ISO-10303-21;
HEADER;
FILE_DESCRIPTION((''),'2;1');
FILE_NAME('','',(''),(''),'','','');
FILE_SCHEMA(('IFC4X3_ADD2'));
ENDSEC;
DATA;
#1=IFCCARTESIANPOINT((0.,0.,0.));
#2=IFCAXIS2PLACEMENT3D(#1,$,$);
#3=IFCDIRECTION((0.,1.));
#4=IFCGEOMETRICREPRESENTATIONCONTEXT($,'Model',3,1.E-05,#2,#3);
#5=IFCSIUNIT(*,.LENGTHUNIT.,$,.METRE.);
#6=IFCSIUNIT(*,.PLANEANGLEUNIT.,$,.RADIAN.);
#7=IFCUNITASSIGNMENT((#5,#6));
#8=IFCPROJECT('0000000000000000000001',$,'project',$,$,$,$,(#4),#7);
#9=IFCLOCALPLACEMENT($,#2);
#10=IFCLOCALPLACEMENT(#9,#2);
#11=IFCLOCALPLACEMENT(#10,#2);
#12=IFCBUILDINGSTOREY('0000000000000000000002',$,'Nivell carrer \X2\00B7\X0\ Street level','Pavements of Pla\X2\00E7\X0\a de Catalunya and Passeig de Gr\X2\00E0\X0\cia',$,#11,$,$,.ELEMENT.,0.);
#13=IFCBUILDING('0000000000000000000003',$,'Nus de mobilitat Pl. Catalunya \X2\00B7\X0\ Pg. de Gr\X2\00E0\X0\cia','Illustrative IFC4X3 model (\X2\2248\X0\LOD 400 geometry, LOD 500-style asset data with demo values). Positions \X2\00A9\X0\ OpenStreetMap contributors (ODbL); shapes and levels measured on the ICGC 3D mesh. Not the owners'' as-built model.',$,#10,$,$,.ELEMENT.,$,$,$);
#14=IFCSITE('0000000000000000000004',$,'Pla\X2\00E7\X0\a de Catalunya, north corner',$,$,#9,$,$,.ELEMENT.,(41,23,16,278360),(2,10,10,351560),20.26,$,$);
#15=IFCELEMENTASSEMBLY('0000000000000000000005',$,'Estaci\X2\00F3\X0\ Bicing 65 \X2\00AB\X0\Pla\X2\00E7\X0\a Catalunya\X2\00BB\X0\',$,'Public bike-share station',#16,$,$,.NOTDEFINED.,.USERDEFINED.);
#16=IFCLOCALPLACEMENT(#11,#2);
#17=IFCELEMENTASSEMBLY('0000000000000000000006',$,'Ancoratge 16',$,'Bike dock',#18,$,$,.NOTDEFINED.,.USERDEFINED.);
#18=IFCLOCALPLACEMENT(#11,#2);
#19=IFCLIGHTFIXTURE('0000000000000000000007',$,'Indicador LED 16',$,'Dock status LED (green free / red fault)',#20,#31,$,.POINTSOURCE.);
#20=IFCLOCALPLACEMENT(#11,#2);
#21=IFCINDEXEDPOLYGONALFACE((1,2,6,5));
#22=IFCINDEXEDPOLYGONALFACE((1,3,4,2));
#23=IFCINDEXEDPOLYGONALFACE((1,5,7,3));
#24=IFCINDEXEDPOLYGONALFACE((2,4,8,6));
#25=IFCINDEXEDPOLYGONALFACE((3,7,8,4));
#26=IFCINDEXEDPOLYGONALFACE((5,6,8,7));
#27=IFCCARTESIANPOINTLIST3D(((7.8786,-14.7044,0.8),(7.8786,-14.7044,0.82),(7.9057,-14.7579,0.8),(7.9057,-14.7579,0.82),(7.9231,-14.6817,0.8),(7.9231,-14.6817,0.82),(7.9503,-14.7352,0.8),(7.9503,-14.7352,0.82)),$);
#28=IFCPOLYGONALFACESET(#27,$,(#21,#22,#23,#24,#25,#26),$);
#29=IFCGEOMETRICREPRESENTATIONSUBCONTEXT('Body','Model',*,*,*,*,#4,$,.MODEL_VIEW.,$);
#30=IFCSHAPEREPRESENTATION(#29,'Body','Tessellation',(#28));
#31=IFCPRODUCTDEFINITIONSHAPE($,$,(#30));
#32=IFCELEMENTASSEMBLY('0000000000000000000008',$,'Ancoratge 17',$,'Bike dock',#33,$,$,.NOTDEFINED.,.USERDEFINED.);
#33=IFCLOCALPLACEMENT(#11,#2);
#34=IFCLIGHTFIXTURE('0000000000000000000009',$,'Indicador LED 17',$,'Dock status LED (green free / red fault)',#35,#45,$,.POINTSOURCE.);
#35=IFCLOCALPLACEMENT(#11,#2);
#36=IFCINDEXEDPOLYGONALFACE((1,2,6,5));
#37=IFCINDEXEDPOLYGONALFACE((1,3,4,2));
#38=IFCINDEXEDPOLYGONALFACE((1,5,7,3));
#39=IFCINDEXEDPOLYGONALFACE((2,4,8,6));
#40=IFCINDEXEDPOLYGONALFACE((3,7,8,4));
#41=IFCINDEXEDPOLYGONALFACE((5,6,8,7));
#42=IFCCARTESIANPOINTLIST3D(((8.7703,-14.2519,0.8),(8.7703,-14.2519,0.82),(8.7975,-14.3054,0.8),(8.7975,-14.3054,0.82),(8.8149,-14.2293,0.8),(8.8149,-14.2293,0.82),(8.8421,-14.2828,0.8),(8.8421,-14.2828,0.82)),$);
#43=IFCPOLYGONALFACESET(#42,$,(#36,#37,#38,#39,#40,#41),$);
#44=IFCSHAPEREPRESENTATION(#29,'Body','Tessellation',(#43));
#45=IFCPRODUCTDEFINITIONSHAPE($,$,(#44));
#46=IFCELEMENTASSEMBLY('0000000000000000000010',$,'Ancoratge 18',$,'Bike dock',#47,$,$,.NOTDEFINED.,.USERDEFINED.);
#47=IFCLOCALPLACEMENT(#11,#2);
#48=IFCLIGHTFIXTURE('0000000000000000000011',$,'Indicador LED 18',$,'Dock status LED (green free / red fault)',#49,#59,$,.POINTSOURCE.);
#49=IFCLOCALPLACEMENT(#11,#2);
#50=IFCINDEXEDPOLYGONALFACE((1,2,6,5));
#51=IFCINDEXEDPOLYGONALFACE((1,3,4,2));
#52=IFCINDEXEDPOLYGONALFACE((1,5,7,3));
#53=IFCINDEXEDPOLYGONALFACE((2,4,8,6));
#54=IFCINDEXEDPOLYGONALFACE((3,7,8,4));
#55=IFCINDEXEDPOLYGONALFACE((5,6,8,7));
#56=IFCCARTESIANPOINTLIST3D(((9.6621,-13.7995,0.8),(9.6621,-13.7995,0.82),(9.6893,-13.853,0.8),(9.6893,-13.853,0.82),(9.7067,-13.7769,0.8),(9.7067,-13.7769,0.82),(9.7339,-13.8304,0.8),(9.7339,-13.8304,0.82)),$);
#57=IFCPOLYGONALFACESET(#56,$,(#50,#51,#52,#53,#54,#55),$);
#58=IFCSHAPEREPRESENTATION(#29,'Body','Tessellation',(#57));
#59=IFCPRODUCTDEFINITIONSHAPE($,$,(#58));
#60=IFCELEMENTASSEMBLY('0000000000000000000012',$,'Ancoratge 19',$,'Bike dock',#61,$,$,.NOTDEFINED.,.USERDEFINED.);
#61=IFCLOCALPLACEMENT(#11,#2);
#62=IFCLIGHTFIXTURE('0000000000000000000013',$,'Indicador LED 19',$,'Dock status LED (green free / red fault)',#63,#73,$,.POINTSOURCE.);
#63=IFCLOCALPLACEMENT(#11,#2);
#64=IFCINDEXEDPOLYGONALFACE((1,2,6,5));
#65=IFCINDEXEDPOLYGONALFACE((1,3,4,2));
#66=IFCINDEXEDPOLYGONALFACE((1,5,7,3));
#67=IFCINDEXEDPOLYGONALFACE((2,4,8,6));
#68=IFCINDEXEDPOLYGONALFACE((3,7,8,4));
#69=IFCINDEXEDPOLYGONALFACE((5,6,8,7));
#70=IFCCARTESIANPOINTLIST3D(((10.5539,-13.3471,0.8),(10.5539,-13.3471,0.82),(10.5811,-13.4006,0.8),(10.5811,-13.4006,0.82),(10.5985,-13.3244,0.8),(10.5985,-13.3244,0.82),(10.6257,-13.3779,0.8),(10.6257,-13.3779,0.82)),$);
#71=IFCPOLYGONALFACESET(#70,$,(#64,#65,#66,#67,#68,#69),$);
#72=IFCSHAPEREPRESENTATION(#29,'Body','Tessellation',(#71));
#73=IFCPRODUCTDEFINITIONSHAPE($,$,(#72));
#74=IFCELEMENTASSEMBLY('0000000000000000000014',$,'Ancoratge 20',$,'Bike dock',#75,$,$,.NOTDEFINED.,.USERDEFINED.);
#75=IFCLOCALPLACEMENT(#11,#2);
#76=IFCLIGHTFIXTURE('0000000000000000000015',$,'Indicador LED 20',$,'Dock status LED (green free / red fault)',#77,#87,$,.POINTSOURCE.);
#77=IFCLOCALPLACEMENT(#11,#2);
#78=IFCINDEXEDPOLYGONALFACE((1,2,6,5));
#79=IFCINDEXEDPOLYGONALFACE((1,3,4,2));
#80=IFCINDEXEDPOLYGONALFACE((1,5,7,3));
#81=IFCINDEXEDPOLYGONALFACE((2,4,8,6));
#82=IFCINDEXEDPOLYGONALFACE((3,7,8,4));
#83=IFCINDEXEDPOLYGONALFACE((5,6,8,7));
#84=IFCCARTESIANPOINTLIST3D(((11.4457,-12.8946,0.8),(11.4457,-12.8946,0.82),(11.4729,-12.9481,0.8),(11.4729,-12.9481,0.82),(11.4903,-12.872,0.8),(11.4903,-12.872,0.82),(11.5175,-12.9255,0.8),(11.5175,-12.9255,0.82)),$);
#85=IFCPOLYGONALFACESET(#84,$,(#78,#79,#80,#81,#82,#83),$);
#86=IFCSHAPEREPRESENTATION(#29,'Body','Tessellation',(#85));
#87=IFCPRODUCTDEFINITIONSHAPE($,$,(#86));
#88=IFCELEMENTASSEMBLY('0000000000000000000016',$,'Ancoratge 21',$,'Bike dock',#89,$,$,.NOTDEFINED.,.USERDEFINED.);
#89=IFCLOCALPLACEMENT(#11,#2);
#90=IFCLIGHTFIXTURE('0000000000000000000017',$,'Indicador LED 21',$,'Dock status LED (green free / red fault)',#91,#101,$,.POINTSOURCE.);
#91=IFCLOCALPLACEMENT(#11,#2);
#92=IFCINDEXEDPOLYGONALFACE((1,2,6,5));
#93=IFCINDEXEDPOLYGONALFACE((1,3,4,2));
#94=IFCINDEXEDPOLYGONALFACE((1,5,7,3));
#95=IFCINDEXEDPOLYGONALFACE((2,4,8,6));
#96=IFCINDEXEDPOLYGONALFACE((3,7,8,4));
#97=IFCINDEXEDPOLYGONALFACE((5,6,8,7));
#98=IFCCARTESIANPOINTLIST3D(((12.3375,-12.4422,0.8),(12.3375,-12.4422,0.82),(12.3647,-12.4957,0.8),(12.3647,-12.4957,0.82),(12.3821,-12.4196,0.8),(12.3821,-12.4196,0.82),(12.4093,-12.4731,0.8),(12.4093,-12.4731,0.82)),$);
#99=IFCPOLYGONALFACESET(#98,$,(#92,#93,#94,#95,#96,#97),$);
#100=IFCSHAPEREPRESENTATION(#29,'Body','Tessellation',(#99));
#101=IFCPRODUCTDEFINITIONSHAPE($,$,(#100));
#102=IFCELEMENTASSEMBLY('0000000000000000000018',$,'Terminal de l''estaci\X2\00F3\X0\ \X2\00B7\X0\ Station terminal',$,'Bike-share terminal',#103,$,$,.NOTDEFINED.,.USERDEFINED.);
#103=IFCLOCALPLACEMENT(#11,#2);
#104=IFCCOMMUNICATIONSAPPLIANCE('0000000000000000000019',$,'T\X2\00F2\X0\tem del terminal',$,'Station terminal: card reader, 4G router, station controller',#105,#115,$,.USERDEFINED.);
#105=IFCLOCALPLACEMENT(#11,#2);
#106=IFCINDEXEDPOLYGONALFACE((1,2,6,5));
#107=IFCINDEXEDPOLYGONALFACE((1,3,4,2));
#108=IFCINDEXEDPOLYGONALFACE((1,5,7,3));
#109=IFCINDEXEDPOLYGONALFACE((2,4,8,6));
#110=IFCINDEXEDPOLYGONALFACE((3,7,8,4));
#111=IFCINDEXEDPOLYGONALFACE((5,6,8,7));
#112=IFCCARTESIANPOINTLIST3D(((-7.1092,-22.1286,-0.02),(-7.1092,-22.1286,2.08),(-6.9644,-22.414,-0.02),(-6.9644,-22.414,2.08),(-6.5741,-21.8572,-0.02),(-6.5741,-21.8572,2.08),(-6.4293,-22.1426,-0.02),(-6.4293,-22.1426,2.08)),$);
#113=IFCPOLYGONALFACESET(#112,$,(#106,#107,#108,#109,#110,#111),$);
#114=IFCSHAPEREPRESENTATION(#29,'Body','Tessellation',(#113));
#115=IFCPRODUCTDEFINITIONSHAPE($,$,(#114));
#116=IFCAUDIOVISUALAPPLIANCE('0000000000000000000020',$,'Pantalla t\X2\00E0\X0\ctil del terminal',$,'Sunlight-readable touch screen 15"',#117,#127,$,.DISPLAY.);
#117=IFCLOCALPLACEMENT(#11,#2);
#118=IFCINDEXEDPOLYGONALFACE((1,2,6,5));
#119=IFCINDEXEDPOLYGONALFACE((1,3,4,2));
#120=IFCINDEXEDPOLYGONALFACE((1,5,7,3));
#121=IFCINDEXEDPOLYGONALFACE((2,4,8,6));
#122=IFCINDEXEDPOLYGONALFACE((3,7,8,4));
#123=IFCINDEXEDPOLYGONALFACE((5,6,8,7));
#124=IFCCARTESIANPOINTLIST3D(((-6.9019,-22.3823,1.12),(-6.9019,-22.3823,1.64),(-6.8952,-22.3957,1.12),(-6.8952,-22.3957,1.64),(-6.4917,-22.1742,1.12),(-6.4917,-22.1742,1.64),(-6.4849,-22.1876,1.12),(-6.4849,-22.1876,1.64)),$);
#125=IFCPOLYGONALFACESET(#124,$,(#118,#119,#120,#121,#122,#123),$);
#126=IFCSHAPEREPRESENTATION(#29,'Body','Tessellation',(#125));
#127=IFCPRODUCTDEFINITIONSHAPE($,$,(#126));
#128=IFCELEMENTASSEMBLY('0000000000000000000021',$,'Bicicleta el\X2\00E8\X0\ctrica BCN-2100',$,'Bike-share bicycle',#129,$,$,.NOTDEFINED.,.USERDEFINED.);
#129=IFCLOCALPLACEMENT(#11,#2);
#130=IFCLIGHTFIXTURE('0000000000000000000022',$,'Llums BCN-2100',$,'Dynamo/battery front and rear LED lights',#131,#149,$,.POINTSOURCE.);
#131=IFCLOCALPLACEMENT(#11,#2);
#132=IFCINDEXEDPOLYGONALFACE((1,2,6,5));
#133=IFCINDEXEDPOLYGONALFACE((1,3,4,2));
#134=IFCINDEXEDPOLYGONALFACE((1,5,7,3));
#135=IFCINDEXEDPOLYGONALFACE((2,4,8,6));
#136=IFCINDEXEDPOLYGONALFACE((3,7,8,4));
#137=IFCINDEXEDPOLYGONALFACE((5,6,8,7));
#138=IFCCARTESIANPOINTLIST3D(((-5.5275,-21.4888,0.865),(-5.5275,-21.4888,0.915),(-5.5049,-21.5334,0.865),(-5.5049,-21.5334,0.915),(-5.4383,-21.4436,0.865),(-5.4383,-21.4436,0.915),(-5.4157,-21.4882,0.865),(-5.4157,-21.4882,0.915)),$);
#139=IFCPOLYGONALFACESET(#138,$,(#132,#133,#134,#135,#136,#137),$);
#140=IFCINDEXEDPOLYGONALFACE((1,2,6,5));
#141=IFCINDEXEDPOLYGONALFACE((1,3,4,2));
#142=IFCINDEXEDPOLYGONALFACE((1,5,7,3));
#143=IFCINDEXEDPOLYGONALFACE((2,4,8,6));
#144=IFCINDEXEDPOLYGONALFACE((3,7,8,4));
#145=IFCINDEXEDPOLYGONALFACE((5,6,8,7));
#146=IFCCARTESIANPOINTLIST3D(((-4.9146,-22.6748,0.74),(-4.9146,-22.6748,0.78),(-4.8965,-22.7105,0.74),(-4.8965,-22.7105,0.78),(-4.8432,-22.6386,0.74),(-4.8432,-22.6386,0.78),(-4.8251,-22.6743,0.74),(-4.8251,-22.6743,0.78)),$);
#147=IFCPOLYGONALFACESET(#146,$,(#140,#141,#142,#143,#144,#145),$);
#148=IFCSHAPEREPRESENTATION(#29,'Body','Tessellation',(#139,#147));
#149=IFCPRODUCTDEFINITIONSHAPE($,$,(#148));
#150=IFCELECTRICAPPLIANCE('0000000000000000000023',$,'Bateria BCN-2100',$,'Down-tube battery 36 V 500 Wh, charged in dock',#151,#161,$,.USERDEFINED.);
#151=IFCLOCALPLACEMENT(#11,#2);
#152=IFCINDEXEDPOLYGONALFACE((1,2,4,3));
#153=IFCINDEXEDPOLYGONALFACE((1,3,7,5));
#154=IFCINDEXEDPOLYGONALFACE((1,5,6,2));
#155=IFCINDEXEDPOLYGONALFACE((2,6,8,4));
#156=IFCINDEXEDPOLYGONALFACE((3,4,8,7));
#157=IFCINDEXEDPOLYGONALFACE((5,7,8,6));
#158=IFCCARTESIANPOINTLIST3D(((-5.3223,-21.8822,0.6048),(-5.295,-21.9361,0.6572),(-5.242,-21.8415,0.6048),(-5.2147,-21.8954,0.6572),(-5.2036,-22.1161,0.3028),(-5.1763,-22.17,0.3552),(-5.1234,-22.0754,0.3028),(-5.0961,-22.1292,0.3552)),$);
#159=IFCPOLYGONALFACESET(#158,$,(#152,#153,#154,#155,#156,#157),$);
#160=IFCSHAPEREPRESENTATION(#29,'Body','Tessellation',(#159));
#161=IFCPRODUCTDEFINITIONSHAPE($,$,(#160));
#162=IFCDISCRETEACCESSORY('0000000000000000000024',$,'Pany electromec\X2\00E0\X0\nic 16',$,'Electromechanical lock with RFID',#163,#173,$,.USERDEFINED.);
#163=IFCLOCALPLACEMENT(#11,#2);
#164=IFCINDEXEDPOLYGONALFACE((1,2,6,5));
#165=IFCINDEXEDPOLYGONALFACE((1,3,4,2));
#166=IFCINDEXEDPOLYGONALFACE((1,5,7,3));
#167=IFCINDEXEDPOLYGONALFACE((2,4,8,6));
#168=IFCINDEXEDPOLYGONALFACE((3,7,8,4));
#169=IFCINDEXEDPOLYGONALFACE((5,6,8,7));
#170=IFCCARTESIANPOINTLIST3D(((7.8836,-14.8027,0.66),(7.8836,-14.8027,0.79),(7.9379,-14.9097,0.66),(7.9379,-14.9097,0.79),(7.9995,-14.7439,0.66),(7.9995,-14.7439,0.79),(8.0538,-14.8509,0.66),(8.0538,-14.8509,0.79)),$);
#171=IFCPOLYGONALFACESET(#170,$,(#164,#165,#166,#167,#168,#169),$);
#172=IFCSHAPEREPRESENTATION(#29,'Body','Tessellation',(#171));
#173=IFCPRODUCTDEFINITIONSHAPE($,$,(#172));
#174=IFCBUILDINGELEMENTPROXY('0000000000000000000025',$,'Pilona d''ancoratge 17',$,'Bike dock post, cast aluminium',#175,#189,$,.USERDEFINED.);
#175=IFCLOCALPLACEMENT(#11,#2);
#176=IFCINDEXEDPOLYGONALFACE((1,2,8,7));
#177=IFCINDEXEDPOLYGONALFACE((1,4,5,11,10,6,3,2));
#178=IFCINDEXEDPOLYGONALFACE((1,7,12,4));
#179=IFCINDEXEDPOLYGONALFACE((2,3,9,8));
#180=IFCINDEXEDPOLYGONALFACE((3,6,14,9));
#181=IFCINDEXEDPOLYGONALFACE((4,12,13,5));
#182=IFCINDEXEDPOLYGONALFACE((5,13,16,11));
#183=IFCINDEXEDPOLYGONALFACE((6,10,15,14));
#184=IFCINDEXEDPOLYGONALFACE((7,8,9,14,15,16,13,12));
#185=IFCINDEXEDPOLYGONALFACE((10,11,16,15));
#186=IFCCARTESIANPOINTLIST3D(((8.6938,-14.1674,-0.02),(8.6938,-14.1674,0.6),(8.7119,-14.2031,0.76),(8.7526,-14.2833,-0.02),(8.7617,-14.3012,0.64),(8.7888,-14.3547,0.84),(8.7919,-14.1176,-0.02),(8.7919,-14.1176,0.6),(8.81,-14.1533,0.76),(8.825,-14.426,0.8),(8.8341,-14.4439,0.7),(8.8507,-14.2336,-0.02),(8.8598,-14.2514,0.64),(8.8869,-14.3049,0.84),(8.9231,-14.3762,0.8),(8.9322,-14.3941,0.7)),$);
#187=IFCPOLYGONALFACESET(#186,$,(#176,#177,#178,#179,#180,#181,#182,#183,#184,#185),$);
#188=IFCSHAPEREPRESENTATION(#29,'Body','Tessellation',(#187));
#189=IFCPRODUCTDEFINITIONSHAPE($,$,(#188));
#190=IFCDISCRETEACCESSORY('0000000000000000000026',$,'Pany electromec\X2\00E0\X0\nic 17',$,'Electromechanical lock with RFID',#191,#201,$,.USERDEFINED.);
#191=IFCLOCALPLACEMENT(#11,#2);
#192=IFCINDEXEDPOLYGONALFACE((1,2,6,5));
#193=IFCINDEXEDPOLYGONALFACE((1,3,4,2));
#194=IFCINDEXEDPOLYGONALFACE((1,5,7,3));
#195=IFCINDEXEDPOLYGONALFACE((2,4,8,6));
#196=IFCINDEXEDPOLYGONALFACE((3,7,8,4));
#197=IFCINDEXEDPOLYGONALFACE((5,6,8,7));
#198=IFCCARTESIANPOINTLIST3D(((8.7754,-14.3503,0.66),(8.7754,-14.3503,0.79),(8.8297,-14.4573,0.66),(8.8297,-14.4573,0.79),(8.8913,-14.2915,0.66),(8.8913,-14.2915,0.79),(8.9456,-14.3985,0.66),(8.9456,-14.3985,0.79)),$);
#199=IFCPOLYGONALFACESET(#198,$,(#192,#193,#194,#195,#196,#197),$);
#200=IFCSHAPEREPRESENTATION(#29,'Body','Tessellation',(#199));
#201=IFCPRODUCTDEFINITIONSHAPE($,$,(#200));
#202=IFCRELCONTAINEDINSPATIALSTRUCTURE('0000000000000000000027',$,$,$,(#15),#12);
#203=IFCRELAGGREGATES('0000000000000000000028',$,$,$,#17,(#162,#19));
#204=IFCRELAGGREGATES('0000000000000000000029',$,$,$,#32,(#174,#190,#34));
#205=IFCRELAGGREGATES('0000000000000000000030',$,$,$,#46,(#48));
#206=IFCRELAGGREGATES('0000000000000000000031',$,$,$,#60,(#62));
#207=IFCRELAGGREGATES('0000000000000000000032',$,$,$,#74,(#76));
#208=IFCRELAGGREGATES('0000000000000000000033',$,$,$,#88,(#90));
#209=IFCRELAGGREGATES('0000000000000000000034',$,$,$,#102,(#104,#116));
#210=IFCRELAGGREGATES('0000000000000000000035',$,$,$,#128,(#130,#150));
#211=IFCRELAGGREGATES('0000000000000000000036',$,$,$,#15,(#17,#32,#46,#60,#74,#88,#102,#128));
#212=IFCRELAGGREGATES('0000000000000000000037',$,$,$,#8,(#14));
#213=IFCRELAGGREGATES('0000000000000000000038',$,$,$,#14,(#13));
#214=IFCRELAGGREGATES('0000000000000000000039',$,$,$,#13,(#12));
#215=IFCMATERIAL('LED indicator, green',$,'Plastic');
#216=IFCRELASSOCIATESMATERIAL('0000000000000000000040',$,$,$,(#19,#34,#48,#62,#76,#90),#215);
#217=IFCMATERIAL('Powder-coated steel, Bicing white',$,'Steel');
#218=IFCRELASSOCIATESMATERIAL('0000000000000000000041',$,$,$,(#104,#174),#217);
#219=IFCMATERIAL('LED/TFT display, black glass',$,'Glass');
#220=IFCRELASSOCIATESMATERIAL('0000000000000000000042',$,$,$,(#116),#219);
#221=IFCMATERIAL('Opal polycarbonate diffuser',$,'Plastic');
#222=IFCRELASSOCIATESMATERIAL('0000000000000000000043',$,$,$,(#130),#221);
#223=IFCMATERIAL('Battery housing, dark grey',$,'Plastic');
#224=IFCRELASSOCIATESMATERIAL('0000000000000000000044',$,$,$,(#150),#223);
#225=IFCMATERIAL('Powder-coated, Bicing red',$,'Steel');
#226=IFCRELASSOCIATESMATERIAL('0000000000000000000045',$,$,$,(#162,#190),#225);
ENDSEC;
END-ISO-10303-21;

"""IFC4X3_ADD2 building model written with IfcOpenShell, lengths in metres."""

from ifc_helpers import new_model, si_unit, direction, frame, frame_2d, origin, origin_2d_with_axis, place, context, subcontext, project, spatial, polyline, rectangle, outline, extrude, material, element, aggregate, save


model = new_model("IFC4X3_ADD2")

# Units and contexts
model_context = context("Model", 3, precision=1e-05, world=origin(), true_north=direction((0.0, 1.0)))
body_context = subcontext(model_context, "Body", "Model", "MODEL_VIEW")
ifc_project = project(units=[si_unit("LENGTHUNIT", "METRE"), si_unit("PLANEANGLEUNIT", "RADIAN")], contexts=[model_context])

# Site, building, storey
site_placement = place(None, origin())
site = spatial("IfcSite", under=ifc_project, at=site_placement, Name="Plaça de Catalunya, north corner", CompositionType="ELEMENT", RefLatitude=(41, 23, 16, 278360), RefLongitude=(2, 10, 10, 351560), RefElevation=20.26)
building_placement = place(site_placement, origin())
building = spatial("IfcBuilding", under=site, at=building_placement, Name="Nus de mobilitat Pl. Catalunya · Pg. de Gràcia", Description="Illustrative IFC4X3 model (≈LOD 400 geometry, LOD 500-style asset data with demo values). Positions © OpenStreetMap contributors (ODbL); shapes and levels measured on the ICGC 3D mesh. Not the owners' as-built model.", CompositionType="ELEMENT")
storey_placement = place(building_placement, origin())
storey = spatial("IfcBuildingStorey", under=building, at=storey_placement, Name="Nivell carrer · Street level", Description="Pavements of Plaça de Catalunya and Passeig de Gràcia", CompositionType="ELEMENT", Elevation=0.0)

# Element assemblies, light fixtures, communications appliance, audio visual appliance, electric appliance, discrete accessories, building element proxy
assembly_1_placement = place(building_placement, origin())
assembly_1 = element("IfcElementAssembly", 1, at=assembly_1_placement, inside=storey, Name="Estació Bicing 65 «Plaça Catalunya»", ObjectType="Public bike-share station", AssemblyPlace="NOTDEFINED", PredefinedType="USERDEFINED")
assembly_2_placement = place(building_placement, origin())
assembly_2 = element("IfcElementAssembly", 2, at=assembly_2_placement, Name="Ancoratge 16", ObjectType="Bike dock", AssemblyPlace="NOTDEFINED", PredefinedType="USERDEFINED")
ifc_material_1 = material(Name="LED indicator, green", Category="Plastic")
light_fixture_1_placement = place(building_placement, origin())
light_fixture_1 = element("IfcLightFixture", 3, at=light_fixture_1_placement, material=ifc_material_1, Name="Indicador LED 16", ObjectType="Dock status LED (green free / red fault)", PredefinedType="POINTSOURCE", context=body_context, shape_type="SweptSolid", body=[
    extrude(rectangle(XDim=0.05, YDim=0.06, at=frame_2d((0.0, 0.0), x_axis=(0.891798, 0.452435))), frame((7.9144, -14.7198, 0.8)), (0.0, 0.0, 1.0), 0.02),
])
assembly_3_placement = place(building_placement, origin())
assembly_3 = element("IfcElementAssembly", 4, at=assembly_3_placement, Name="Ancoratge 17", ObjectType="Bike dock", AssemblyPlace="NOTDEFINED", PredefinedType="USERDEFINED")
light_fixture_2_placement = place(building_placement, origin())
light_fixture_2 = element("IfcLightFixture", 5, at=light_fixture_2_placement, material=ifc_material_1, Name="Indicador LED 17", ObjectType="Dock status LED (green free / red fault)", PredefinedType="POINTSOURCE", context=body_context, shape_type="SweptSolid", body=[
    extrude(rectangle(XDim=0.05, YDim=0.06, at=frame_2d((0.0, 0.0), x_axis=(0.891798, 0.452435))), frame((8.8062, -14.2674, 0.8)), (0.0, 0.0, 1.0), 0.02),
])
assembly_4_placement = place(building_placement, origin())
assembly_4 = element("IfcElementAssembly", 6, at=assembly_4_placement, Name="Ancoratge 18", ObjectType="Bike dock", AssemblyPlace="NOTDEFINED", PredefinedType="USERDEFINED")
light_fixture_3_placement = place(building_placement, origin())
light_fixture_3 = element("IfcLightFixture", 7, at=light_fixture_3_placement, material=ifc_material_1, Name="Indicador LED 18", ObjectType="Dock status LED (green free / red fault)", PredefinedType="POINTSOURCE", context=body_context, shape_type="SweptSolid", body=[
    extrude(rectangle(XDim=0.05, YDim=0.06, at=frame_2d((0.0, 0.0), x_axis=(0.891798, 0.452435))), frame((9.698, -13.8149, 0.8)), (0.0, 0.0, 1.0), 0.02),
])
assembly_5_placement = place(building_placement, origin())
assembly_5 = element("IfcElementAssembly", 8, at=assembly_5_placement, Name="Ancoratge 19", ObjectType="Bike dock", AssemblyPlace="NOTDEFINED", PredefinedType="USERDEFINED")
light_fixture_4_placement = place(building_placement, origin())
light_fixture_4 = element("IfcLightFixture", 9, at=light_fixture_4_placement, material=ifc_material_1, Name="Indicador LED 19", ObjectType="Dock status LED (green free / red fault)", PredefinedType="POINTSOURCE", context=body_context, shape_type="SweptSolid", body=[
    extrude(rectangle(XDim=0.05, YDim=0.06, at=frame_2d((0.0, 0.0), x_axis=(0.891798, 0.452435))), frame((10.5898, -13.3625, 0.8)), (0.0, 0.0, 1.0), 0.02),
])
assembly_6_placement = place(building_placement, origin())
assembly_6 = element("IfcElementAssembly", 10, at=assembly_6_placement, Name="Ancoratge 20", ObjectType="Bike dock", AssemblyPlace="NOTDEFINED", PredefinedType="USERDEFINED")
light_fixture_5_placement = place(building_placement, origin())
light_fixture_5 = element("IfcLightFixture", 11, at=light_fixture_5_placement, material=ifc_material_1, Name="Indicador LED 20", ObjectType="Dock status LED (green free / red fault)", PredefinedType="POINTSOURCE", context=body_context, shape_type="SweptSolid", body=[
    extrude(rectangle(XDim=0.05, YDim=0.06, at=frame_2d((0.0, 0.0), x_axis=(0.891798, 0.452435))), frame((11.4816, -12.9101, 0.8)), (0.0, 0.0, 1.0), 0.02),
])
assembly_7_placement = place(building_placement, origin())
assembly_7 = element("IfcElementAssembly", 12, at=assembly_7_placement, Name="Ancoratge 21", ObjectType="Bike dock", AssemblyPlace="NOTDEFINED", PredefinedType="USERDEFINED")
light_fixture_6_placement = place(building_placement, origin())
light_fixture_6 = element("IfcLightFixture", 13, at=light_fixture_6_placement, material=ifc_material_1, Name="Indicador LED 21", ObjectType="Dock status LED (green free / red fault)", PredefinedType="POINTSOURCE", context=body_context, shape_type="SweptSolid", body=[
    extrude(rectangle(XDim=0.05, YDim=0.06, at=frame_2d((0.0, 0.0), x_axis=(0.891798, 0.452435))), frame((12.3734, -12.4576, 0.8)), (0.0, 0.0, 1.0), 0.02),
])
assembly_8_placement = place(building_placement, origin())
assembly_8 = element("IfcElementAssembly", 14, at=assembly_8_placement, Name="Terminal de l'estació · Station terminal", ObjectType="Bike-share terminal", AssemblyPlace="NOTDEFINED", PredefinedType="USERDEFINED")
ifc_material_2 = material(Name="Powder-coated steel, Bicing white", Category="Steel")
communications_appliance_placement = place(building_placement, origin())
communications_appliance = element("IfcCommunicationsAppliance", 15, at=communications_appliance_placement, material=ifc_material_2, Name="Tòtem del terminal", ObjectType="Station terminal: card reader, 4G router, station controller", PredefinedType="USERDEFINED", context=body_context, shape_type="SweptSolid", body=[
    extrude(rectangle(XDim=0.6, YDim=0.32, at=frame_2d((0.0, 0.0), x_axis=(0.891798, 0.452435))), frame((-6.7692, -22.1356, -0.02)), (0.0, 0.0, 1.0), 2.1),
])
ifc_material_3 = material(Name="LED/TFT display, black glass", Category="Glass")
audio_visual_appliance_placement = place(building_placement, origin())
audio_visual_appliance = element("IfcAudioVisualAppliance", 16, at=audio_visual_appliance_placement, material=ifc_material_3, Name="Pantalla tàctil del terminal", ObjectType="Sunlight-readable touch screen 15\"", PredefinedType="DISPLAY", context=body_context, shape_type="SweptSolid", body=[
    extrude(rectangle(XDim=0.46, YDim=0.015, at=frame_2d((0.0, 0.0), x_axis=(0.891798, 0.452435))), frame((-6.6934, -22.285, 1.12)), (0.0, 0.0, 1.0), 0.52),
])
assembly_9_placement = place(building_placement, origin())
assembly_9 = element("IfcElementAssembly", 17, at=assembly_9_placement, Name="Bicicleta elèctrica BCN-2100", ObjectType="Bike-share bicycle", AssemblyPlace="NOTDEFINED", PredefinedType="USERDEFINED")
ifc_material_4 = material(Name="Opal polycarbonate diffuser", Category="Plastic")
light_fixture_7_placement = place(building_placement, origin())
light_fixture_7 = element("IfcLightFixture", 18, at=light_fixture_7_placement, material=ifc_material_4, Name="Llums BCN-2100", ObjectType="Dynamo/battery front and rear LED lights", PredefinedType="POINTSOURCE", context=body_context, shape_type="SweptSolid", body=[
    extrude(rectangle(XDim=0.05, YDim=0.1, at=origin_2d_with_axis()), frame((-5.4716, -21.4885, 0.915), z_axis=(0.0, 0.0, -1.0), x_axis=(-0.452435, 0.891798, 0.0)), (0.0, 0.0, 1.0), 0.05),
    extrude(rectangle(XDim=0.04, YDim=0.08, at=origin_2d_with_axis()), frame((-4.8699, -22.6746, 0.78), z_axis=(0.0, 0.0, -1.0), x_axis=(-0.452435, 0.891798, 0.0)), (0.0, 0.0, 1.0), 0.04),
])
ifc_material_5 = material(Name="Battery housing, dark grey", Category="Plastic")
electric_appliance_placement = place(building_placement, origin())
electric_appliance = element("IfcElectricAppliance", 19, at=electric_appliance_placement, material=ifc_material_5, Name="Bateria BCN-2100", ObjectType="Down-tube battery 36 V 500 Wh, charged in dock", PredefinedType="USERDEFINED", context=body_context, shape_type="SweptSolid", body=[
    extrude(rectangle(XDim=0.4, YDim=0.09, at=origin_2d_with_axis()), frame((-5.1955, -22.0327, 0.5062), z_axis=(-0.341603, 0.673337, -0.655687), x_axis=(-0.296655, 0.58474, 0.755033)), (0.0, 0.0, 1.0), 0.08),
])
ifc_material_6 = material(Name="Powder-coated, Bicing red", Category="Steel")
discrete_accessory_1_placement = place(building_placement, origin())
discrete_accessory_1 = element("IfcDiscreteAccessory", 20, at=discrete_accessory_1_placement, material=ifc_material_6, Name="Pany electromecànic 16", ObjectType="Electromechanical lock with RFID", PredefinedType="USERDEFINED", context=body_context, shape_type="SweptSolid", body=[
    extrude(rectangle(XDim=0.13, YDim=0.12, at=frame_2d((0.0, 0.0), x_axis=(0.891798, 0.452435))), frame((7.9687, -14.8268, 0.66)), (0.0, 0.0, 1.0), 0.13),
])
aggregate(assembly_2, [discrete_accessory_1, light_fixture_1])
proxy_1_placement = place(building_placement, origin())
proxy_1 = element("IfcBuildingElementProxy", 21, at=proxy_1_placement, material=ifc_material_2, Name="Pilona d'ancoratge 17", ObjectType="Bike dock post, cast aluminium", PredefinedType="USERDEFINED", context=body_context, shape_type="SweptSolid", body=[
    extrude(outline(polyline([(0.07, 0.06), (0.07, 0.68), (0.03, 0.84), (-0.14, 0.92), (-0.22, 0.88), (-0.24, 0.78), (-0.08, 0.72), (-0.06, 0.06), (0.07, 0.06)])), frame((8.7255, -14.2298, -0.08), z_axis=(0.891798, 0.452435, 0.0), x_axis=(-0.452435, 0.891798, 0.0)), (0.0, 0.0, 1.0), 0.11),
])
discrete_accessory_2_placement = place(building_placement, origin())
discrete_accessory_2 = element("IfcDiscreteAccessory", 22, at=discrete_accessory_2_placement, material=ifc_material_6, Name="Pany electromecànic 17", ObjectType="Electromechanical lock with RFID", PredefinedType="USERDEFINED", context=body_context, shape_type="SweptSolid", body=[
    extrude(rectangle(XDim=0.13, YDim=0.12, at=frame_2d((0.0, 0.0), x_axis=(0.891798, 0.452435))), frame((8.8605, -14.3744, 0.66)), (0.0, 0.0, 1.0), 0.13),
])
aggregate(assembly_3, [proxy_1, discrete_accessory_2, light_fixture_2])
aggregate(assembly_4, [light_fixture_3])
aggregate(assembly_5, [light_fixture_4])
aggregate(assembly_6, [light_fixture_5])
aggregate(assembly_7, [light_fixture_6])
aggregate(assembly_8, [communications_appliance, audio_visual_appliance])
aggregate(assembly_9, [light_fixture_7, electric_appliance])
aggregate(assembly_1, [assembly_2, assembly_3, assembly_4, assembly_5, assembly_6, assembly_7, assembly_8, assembly_9])

save(model, "model.ifc")
